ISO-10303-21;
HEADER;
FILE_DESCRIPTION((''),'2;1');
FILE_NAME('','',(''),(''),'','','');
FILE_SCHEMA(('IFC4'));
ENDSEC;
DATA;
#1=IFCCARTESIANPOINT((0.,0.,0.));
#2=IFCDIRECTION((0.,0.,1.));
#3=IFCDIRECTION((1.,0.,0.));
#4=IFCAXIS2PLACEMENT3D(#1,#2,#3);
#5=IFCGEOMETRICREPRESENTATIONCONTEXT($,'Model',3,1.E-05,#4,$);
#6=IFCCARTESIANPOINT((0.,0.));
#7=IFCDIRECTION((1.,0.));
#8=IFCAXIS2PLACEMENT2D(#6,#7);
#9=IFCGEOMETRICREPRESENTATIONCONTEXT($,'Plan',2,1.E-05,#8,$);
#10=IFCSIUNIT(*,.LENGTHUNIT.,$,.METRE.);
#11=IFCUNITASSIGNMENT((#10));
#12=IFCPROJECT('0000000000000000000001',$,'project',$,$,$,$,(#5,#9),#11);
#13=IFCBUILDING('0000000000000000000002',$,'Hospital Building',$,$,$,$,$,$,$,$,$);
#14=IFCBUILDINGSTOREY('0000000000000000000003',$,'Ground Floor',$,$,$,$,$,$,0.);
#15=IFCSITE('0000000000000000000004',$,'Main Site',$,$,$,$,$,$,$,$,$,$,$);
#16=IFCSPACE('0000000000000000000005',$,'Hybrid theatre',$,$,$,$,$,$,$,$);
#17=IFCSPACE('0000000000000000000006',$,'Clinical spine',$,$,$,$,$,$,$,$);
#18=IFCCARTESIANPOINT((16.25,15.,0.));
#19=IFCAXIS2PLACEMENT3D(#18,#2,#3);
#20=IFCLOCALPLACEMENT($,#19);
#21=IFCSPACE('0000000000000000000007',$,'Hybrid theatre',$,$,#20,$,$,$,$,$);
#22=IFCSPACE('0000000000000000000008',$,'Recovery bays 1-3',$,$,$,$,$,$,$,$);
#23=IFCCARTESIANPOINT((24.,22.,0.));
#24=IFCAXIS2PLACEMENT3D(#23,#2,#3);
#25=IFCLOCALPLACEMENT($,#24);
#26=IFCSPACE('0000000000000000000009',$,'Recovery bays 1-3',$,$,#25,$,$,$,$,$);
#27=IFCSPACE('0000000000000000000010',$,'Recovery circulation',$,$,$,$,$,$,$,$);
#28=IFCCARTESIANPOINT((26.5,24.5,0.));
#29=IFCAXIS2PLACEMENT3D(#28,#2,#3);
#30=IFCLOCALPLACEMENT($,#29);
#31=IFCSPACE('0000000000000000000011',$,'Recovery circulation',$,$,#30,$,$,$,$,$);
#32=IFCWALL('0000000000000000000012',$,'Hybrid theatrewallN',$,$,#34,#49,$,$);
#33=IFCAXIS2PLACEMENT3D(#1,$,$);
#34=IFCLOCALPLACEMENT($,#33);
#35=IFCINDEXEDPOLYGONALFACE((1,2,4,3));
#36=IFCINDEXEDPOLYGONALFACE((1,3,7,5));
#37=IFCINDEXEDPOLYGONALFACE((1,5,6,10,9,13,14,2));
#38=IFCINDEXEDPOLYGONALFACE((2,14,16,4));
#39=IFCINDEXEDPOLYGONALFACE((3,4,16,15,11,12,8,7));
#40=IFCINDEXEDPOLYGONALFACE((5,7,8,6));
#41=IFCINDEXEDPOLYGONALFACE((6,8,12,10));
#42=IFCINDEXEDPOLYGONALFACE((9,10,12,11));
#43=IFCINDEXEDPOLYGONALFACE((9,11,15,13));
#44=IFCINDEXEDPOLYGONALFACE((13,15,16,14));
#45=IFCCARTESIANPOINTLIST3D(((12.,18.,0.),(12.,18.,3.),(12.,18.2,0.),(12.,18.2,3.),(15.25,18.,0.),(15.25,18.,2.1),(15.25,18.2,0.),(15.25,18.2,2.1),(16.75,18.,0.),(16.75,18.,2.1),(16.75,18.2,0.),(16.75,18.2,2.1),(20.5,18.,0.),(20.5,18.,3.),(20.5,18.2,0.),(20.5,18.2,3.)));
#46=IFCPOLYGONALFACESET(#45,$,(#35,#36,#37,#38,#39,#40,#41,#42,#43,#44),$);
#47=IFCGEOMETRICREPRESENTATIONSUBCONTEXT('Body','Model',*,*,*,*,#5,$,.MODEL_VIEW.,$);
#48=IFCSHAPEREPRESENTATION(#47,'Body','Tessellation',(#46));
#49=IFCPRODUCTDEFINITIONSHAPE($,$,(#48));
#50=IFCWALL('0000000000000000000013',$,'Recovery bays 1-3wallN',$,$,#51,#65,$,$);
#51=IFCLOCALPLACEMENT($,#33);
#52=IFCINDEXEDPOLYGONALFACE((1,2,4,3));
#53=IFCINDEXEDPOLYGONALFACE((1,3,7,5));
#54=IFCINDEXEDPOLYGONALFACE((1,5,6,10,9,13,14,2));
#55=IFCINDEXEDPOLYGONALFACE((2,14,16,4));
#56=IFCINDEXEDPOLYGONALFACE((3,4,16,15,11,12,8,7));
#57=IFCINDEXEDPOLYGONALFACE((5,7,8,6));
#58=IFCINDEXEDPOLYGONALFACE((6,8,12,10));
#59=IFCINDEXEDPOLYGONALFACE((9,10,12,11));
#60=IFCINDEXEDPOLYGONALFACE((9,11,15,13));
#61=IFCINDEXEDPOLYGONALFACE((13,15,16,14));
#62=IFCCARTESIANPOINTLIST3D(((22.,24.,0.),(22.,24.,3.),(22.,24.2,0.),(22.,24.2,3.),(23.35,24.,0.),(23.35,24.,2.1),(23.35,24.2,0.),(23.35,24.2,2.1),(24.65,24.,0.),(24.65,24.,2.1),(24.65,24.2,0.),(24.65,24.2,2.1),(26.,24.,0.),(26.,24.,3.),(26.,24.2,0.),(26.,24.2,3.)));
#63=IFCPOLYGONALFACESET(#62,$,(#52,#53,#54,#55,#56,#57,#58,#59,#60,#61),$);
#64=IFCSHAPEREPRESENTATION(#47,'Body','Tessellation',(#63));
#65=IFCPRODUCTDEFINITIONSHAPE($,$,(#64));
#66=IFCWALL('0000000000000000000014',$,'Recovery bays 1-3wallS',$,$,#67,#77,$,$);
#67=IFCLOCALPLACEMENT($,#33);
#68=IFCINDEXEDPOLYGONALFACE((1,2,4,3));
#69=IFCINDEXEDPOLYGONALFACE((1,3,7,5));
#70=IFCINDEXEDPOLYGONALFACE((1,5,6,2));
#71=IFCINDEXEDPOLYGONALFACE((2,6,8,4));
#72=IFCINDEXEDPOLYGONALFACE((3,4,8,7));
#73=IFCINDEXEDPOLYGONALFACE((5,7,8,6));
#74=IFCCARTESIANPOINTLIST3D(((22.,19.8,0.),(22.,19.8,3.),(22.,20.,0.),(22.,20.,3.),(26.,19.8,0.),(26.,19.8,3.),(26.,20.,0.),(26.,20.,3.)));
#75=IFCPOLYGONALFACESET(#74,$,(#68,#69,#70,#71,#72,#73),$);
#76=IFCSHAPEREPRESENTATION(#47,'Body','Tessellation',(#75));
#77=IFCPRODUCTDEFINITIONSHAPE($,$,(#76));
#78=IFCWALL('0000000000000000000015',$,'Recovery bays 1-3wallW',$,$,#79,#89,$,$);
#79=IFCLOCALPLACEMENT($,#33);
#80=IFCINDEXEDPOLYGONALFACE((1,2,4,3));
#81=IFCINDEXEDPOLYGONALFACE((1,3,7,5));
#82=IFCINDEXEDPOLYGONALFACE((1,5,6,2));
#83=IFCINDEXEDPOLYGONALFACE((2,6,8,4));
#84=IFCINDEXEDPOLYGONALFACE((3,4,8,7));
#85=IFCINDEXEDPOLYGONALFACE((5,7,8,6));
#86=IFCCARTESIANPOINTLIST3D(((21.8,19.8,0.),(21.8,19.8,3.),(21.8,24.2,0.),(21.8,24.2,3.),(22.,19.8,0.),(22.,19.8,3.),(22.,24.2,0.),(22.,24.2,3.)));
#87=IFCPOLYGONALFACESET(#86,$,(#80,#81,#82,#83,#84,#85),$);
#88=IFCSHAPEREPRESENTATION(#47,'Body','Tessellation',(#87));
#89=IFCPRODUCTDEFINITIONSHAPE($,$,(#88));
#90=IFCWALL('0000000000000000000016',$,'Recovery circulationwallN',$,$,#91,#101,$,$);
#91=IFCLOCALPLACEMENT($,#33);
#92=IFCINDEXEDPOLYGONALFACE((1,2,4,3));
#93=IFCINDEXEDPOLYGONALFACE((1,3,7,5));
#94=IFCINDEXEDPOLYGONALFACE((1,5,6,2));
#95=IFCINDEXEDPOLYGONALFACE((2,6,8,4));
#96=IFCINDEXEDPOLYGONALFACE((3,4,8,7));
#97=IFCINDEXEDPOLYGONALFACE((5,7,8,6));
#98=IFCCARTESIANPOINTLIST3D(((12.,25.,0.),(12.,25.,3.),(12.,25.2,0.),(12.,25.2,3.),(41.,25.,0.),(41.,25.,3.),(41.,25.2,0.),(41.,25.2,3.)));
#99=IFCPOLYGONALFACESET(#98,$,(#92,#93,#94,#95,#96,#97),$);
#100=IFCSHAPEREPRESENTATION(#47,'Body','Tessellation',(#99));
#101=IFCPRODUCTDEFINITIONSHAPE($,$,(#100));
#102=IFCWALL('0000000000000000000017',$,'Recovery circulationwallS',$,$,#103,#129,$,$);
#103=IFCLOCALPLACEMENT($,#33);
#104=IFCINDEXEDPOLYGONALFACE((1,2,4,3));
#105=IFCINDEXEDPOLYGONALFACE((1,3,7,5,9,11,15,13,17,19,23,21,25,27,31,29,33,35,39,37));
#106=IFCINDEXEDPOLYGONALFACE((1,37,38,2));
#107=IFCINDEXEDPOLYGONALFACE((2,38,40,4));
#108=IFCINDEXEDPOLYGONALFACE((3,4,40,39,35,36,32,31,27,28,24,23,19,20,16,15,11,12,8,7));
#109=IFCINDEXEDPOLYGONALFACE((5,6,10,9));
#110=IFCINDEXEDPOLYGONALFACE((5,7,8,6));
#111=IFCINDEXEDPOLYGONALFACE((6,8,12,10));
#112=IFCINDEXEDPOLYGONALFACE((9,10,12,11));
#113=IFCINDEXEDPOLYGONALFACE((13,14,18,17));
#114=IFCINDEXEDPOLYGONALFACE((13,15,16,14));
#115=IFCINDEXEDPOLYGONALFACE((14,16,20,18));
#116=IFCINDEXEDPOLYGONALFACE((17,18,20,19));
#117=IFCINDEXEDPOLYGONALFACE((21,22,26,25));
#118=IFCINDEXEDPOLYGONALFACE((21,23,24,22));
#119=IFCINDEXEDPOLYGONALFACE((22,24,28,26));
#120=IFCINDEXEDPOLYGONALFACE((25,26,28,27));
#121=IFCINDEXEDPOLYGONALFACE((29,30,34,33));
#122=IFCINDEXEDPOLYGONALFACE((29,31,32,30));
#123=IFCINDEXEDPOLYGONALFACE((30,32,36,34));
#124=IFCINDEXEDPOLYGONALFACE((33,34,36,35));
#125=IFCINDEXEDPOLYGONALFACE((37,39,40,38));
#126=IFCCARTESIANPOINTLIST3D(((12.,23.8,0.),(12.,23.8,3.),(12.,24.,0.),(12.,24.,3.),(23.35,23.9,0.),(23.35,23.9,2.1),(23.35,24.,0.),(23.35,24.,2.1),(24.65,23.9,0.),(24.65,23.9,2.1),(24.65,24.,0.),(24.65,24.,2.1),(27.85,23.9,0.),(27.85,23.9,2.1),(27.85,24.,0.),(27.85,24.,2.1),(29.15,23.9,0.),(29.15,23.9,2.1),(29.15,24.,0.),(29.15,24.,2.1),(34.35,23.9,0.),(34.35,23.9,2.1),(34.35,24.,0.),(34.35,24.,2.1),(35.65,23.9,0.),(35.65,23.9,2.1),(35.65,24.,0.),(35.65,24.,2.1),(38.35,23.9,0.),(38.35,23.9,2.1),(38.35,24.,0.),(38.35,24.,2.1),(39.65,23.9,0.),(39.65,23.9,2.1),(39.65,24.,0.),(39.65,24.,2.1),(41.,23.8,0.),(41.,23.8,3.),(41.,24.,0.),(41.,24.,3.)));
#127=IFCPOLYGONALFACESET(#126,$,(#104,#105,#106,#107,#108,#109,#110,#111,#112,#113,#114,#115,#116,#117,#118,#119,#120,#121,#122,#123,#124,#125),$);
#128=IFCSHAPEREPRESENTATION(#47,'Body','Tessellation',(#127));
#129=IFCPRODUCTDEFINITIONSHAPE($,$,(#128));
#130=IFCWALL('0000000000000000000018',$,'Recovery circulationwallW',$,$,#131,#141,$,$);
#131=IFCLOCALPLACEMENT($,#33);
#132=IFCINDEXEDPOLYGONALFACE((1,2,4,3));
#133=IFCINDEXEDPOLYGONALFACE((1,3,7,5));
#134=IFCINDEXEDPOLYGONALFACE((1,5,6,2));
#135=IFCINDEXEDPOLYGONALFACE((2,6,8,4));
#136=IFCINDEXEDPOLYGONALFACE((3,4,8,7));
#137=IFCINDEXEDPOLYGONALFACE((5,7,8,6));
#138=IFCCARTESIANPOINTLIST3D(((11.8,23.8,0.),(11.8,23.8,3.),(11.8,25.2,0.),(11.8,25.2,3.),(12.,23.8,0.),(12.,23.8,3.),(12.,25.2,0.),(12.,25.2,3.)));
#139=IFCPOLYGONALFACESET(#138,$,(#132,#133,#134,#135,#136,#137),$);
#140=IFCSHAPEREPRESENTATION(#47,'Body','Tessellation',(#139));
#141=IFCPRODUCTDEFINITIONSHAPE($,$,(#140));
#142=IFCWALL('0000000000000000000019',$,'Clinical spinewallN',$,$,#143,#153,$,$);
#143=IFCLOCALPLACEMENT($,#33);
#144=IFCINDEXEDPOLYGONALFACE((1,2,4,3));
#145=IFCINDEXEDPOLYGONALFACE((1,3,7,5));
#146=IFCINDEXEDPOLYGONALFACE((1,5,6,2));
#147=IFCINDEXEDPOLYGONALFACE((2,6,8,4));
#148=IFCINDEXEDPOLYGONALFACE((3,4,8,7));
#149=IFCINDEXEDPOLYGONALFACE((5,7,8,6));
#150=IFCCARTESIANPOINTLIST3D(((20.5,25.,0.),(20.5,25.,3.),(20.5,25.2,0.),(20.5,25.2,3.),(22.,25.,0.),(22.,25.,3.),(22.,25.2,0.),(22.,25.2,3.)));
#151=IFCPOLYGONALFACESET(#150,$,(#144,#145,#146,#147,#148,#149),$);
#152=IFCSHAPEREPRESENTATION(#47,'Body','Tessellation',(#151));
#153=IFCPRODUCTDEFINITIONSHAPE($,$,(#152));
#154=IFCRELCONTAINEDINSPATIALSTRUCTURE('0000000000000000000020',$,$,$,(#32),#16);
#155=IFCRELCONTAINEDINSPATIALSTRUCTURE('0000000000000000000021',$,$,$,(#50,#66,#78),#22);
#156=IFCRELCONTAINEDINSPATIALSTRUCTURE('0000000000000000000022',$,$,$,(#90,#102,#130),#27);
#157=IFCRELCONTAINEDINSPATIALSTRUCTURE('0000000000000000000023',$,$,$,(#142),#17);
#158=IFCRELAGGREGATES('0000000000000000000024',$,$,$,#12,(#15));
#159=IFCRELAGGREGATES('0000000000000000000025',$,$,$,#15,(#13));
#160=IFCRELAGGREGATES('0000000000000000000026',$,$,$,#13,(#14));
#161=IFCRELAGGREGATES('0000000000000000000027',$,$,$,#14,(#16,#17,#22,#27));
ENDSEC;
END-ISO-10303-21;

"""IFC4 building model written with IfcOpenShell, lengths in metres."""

from ifc_helpers import new_model, si_unit, frame, origin_with_axes, origin_2d_with_axis, place, context, subcontext, project, spatial, indexed_curve, outline, extrude, element, save


model = new_model("IFC4")

# Units and contexts
model_context = context("Model", 3, precision=1e-05, world=origin_with_axes())
plan_context = context("Plan", 2, precision=1e-05, world=origin_2d_with_axis())
body_context = subcontext(model_context, "Body", "Model", "MODEL_VIEW")
ifc_project = project(units=[si_unit("LENGTHUNIT", "METRE")], contexts=[model_context, plan_context])

# Site, building, storey
site = spatial("IfcSite", under=ifc_project, Name="Main Site")
building = spatial("IfcBuilding", under=site, Name="Hospital Building")
storey = spatial("IfcBuildingStorey", under=building, Name="Ground Floor", Elevation=0.0)

# Shared definitions
space_1 = spatial("IfcSpace", under=storey, Name="Hybrid theatre")

# Shared definitions
space_2 = spatial("IfcSpace", under=storey, Name="Clinical spine")

# Wall
wall_1_placement = place(None, frame((12.0, 18.0, 0.0), z_axis=(0.0, 0.0, 1.0), x_axis=(1.0, 0.0, 0.0)))
wall_1 = element("IfcWall", 1, at=wall_1_placement, inside=space_1, Name="Hybrid theatrewallN", context=body_context, shape_type="SweptSolid", body=[
    extrude(outline(indexed_curve([(0.0, 0.0), (0.0, 0.2), (8.5, 0.2), (8.5, 0.0), (0.0, 0.0)], self_intersect=False)), origin_with_axes(), (0.0, 0.0, 1.0), 3.0),
])

# Shared definitions
space_3_placement = place(None, frame((16.25, 15.0, 0.0), z_axis=(0.0, 0.0, 1.0), x_axis=(1.0, 0.0, 0.0)))
space_3 = spatial("IfcSpace", at=space_3_placement, Name="Hybrid theatre")

# Opening
opening_1_placement = place(wall_1_placement, frame((3.25, -0.1, 0.0), z_axis=(0.0, 0.0, 1.0), x_axis=(1.0, 0.0, 0.0)))
element("IfcOpeningElement", 2, at=opening_1_placement, inside=space_3, cuts=wall_1, context=body_context, shape_type="SweptSolid", body=[
    extrude(outline(indexed_curve([(0.0, 0.0), (0.0, 0.4), (1.5, 0.4), (1.5, 0.0), (0.0, 0.0)], self_intersect=False)), origin_with_axes(), (0.0, 0.0, 1.0), 2.1),
])

# Shared definitions
space_4 = spatial("IfcSpace", under=storey, Name="Recovery bays 1-3")

# Wall
wall_2_placement = place(None, frame((22.0, 24.0, 0.0), z_axis=(0.0, 0.0, 1.0), x_axis=(1.0, 0.0, 0.0)))
wall_2 = element("IfcWall", 3, at=wall_2_placement, inside=space_4, Name="Recovery bays 1-3wallN", context=body_context, shape_type="SweptSolid", body=[
    extrude(outline(indexed_curve([(0.0, 0.0), (0.0, 0.2), (4.0, 0.2), (4.0, 0.0), (0.0, 0.0)], self_intersect=False)), origin_with_axes(), (0.0, 0.0, 1.0), 3.0),
])

# Shared definitions
space_5_placement = place(None, frame((24.0, 22.0, 0.0), z_axis=(0.0, 0.0, 1.0), x_axis=(1.0, 0.0, 0.0)))
space_5 = spatial("IfcSpace", at=space_5_placement, Name="Recovery bays 1-3")

# Opening
opening_2_placement = place(wall_2_placement, frame((1.35, -0.1, 0.0), z_axis=(0.0, 0.0, 1.0), x_axis=(1.0, 0.0, 0.0)))
element("IfcOpeningElement", 4, at=opening_2_placement, inside=space_5, cuts=wall_2, context=body_context, shape_type="SweptSolid", body=[
    extrude(outline(indexed_curve([(0.0, 0.0), (0.0, 0.4), (1.3, 0.4), (1.3, 0.0), (0.0, 0.0)], self_intersect=False)), origin_with_axes(), (0.0, 0.0, 1.0), 2.1),
])

# Walls
wall_3_placement = place(None, frame((22.0, 19.8, 0.0), z_axis=(0.0, 0.0, 1.0), x_axis=(1.0, 0.0, 0.0)))
element("IfcWall", 5, at=wall_3_placement, inside=space_4, Name="Recovery bays 1-3wallS", context=body_context, shape_type="SweptSolid", body=[
    extrude(outline(indexed_curve([(0.0, 0.0), (0.0, 0.2), (4.0, 0.2), (4.0, 0.0), (0.0, 0.0)], self_intersect=False)), origin_with_axes(), (0.0, 0.0, 1.0), 3.0),
])
wall_4_placement = place(None, frame((22.0, 19.8, 0.0), z_axis=(0.0, 0.0, 1.0), x_axis=(0.0, 1.0, 0.0)))
element("IfcWall", 6, at=wall_4_placement, inside=space_4, Name="Recovery bays 1-3wallW", context=body_context, shape_type="SweptSolid", body=[
    extrude(outline(indexed_curve([(0.0, 0.0), (0.0, 0.2), (4.4, 0.2), (4.4, 0.0), (0.0, 0.0)], self_intersect=False)), origin_with_axes(), (0.0, 0.0, 1.0), 3.0),
])

# Shared definitions
space_6 = spatial("IfcSpace", under=storey, Name="Recovery circulation")

# Walls
wall_5_placement = place(None, frame((12.0, 25.0, 0.0), z_axis=(0.0, 0.0, 1.0), x_axis=(1.0, 0.0, 0.0)))
element("IfcWall", 7, at=wall_5_placement, inside=space_6, Name="Recovery circulationwallN", context=body_context, shape_type="SweptSolid", body=[
    extrude(outline(indexed_curve([(0.0, 0.0), (0.0, 0.2), (29.0, 0.2), (29.0, 0.0), (0.0, 0.0)], self_intersect=False)), origin_with_axes(), (0.0, 0.0, 1.0), 3.0),
])
wall_6_placement = place(None, frame((12.0, 23.8, 0.0), z_axis=(0.0, 0.0, 1.0), x_axis=(1.0, 0.0, 0.0)))
wall_6 = element("IfcWall", 8, at=wall_6_placement, inside=space_6, Name="Recovery circulationwallS", context=body_context, shape_type="SweptSolid", body=[
    extrude(outline(indexed_curve([(0.0, 0.0), (0.0, 0.2), (29.0, 0.2), (29.0, 0.0), (0.0, 0.0)], self_intersect=False)), origin_with_axes(), (0.0, 0.0, 1.0), 3.0),
])

# Shared definitions
space_7_placement = place(None, frame((26.5, 24.5, 0.0), z_axis=(0.0, 0.0, 1.0), x_axis=(1.0, 0.0, 0.0)))
space_7 = spatial("IfcSpace", at=space_7_placement, Name="Recovery circulation")

# Openings
opening_3_placement = place(wall_6_placement, frame((11.35, 0.1, 0.0), z_axis=(0.0, 0.0, 1.0), x_axis=(1.0, 0.0, 0.0)))
element("IfcOpeningElement", 9, at=opening_3_placement, inside=space_7, cuts=wall_6, context=body_context, shape_type="SweptSolid", body=[
    extrude(outline(indexed_curve([(0.0, 0.0), (0.0, 0.4), (1.3, 0.4), (1.3, 0.0), (0.0, 0.0)], self_intersect=False)), origin_with_axes(), (0.0, 0.0, 1.0), 2.1),
])
opening_4_placement = place(wall_6_placement, frame((15.85, 0.1, 0.0), z_axis=(0.0, 0.0, 1.0), x_axis=(1.0, 0.0, 0.0)))
element("IfcOpeningElement", 10, at=opening_4_placement, inside=space_7, cuts=wall_6, context=body_context, shape_type="SweptSolid", body=[
    extrude(outline(indexed_curve([(0.0, 0.0), (0.0, 0.4), (1.3, 0.4), (1.3, 0.0), (0.0, 0.0)], self_intersect=False)), origin_with_axes(), (0.0, 0.0, 1.0), 2.1),
])
opening_5_placement = place(wall_6_placement, frame((22.35, 0.1, 0.0), z_axis=(0.0, 0.0, 1.0), x_axis=(1.0, 0.0, 0.0)))
element("IfcOpeningElement", 11, at=opening_5_placement, inside=space_7, cuts=wall_6, context=body_context, shape_type="SweptSolid", body=[
    extrude(outline(indexed_curve([(0.0, 0.0), (0.0, 0.4), (1.3, 0.4), (1.3, 0.0), (0.0, 0.0)], self_intersect=False)), origin_with_axes(), (0.0, 0.0, 1.0), 2.1),
])
opening_6_placement = place(wall_6_placement, frame((26.35, 0.1, 0.0), z_axis=(0.0, 0.0, 1.0), x_axis=(1.0, 0.0, 0.0)))
element("IfcOpeningElement", 12, at=opening_6_placement, inside=space_7, cuts=wall_6, context=body_context, shape_type="SweptSolid", body=[
    extrude(outline(indexed_curve([(0.0, 0.0), (0.0, 0.4), (1.3, 0.4), (1.3, 0.0), (0.0, 0.0)], self_intersect=False)), origin_with_axes(), (0.0, 0.0, 1.0), 2.1),
])

# Walls
wall_7_placement = place(None, frame((12.0, 23.8, 0.0), z_axis=(0.0, 0.0, 1.0), x_axis=(0.0, 1.0, 0.0)))
element("IfcWall", 13, at=wall_7_placement, inside=space_6, Name="Recovery circulationwallW", context=body_context, shape_type="SweptSolid", body=[
    extrude(outline(indexed_curve([(0.0, 0.0), (0.0, 0.2), (1.4, 0.2), (1.4, 0.0), (0.0, 0.0)], self_intersect=False)), origin_with_axes(), (0.0, 0.0, 1.0), 3.0),
])
wall_8_placement = place(None, frame((20.5, 25.0, 0.0), z_axis=(0.0, 0.0, 1.0), x_axis=(1.0, 0.0, 0.0)))
element("IfcWall", 14, at=wall_8_placement, inside=space_2, Name="Clinical spinewallN", context=body_context, shape_type="SweptSolid", body=[
    extrude(outline(indexed_curve([(0.0, 0.0), (0.0, 0.2), (1.5, 0.2), (1.5, 0.0), (0.0, 0.0)], self_intersect=False)), origin_with_axes(), (0.0, 0.0, 1.0), 3.0),
])

save(model, "model.ifc")
